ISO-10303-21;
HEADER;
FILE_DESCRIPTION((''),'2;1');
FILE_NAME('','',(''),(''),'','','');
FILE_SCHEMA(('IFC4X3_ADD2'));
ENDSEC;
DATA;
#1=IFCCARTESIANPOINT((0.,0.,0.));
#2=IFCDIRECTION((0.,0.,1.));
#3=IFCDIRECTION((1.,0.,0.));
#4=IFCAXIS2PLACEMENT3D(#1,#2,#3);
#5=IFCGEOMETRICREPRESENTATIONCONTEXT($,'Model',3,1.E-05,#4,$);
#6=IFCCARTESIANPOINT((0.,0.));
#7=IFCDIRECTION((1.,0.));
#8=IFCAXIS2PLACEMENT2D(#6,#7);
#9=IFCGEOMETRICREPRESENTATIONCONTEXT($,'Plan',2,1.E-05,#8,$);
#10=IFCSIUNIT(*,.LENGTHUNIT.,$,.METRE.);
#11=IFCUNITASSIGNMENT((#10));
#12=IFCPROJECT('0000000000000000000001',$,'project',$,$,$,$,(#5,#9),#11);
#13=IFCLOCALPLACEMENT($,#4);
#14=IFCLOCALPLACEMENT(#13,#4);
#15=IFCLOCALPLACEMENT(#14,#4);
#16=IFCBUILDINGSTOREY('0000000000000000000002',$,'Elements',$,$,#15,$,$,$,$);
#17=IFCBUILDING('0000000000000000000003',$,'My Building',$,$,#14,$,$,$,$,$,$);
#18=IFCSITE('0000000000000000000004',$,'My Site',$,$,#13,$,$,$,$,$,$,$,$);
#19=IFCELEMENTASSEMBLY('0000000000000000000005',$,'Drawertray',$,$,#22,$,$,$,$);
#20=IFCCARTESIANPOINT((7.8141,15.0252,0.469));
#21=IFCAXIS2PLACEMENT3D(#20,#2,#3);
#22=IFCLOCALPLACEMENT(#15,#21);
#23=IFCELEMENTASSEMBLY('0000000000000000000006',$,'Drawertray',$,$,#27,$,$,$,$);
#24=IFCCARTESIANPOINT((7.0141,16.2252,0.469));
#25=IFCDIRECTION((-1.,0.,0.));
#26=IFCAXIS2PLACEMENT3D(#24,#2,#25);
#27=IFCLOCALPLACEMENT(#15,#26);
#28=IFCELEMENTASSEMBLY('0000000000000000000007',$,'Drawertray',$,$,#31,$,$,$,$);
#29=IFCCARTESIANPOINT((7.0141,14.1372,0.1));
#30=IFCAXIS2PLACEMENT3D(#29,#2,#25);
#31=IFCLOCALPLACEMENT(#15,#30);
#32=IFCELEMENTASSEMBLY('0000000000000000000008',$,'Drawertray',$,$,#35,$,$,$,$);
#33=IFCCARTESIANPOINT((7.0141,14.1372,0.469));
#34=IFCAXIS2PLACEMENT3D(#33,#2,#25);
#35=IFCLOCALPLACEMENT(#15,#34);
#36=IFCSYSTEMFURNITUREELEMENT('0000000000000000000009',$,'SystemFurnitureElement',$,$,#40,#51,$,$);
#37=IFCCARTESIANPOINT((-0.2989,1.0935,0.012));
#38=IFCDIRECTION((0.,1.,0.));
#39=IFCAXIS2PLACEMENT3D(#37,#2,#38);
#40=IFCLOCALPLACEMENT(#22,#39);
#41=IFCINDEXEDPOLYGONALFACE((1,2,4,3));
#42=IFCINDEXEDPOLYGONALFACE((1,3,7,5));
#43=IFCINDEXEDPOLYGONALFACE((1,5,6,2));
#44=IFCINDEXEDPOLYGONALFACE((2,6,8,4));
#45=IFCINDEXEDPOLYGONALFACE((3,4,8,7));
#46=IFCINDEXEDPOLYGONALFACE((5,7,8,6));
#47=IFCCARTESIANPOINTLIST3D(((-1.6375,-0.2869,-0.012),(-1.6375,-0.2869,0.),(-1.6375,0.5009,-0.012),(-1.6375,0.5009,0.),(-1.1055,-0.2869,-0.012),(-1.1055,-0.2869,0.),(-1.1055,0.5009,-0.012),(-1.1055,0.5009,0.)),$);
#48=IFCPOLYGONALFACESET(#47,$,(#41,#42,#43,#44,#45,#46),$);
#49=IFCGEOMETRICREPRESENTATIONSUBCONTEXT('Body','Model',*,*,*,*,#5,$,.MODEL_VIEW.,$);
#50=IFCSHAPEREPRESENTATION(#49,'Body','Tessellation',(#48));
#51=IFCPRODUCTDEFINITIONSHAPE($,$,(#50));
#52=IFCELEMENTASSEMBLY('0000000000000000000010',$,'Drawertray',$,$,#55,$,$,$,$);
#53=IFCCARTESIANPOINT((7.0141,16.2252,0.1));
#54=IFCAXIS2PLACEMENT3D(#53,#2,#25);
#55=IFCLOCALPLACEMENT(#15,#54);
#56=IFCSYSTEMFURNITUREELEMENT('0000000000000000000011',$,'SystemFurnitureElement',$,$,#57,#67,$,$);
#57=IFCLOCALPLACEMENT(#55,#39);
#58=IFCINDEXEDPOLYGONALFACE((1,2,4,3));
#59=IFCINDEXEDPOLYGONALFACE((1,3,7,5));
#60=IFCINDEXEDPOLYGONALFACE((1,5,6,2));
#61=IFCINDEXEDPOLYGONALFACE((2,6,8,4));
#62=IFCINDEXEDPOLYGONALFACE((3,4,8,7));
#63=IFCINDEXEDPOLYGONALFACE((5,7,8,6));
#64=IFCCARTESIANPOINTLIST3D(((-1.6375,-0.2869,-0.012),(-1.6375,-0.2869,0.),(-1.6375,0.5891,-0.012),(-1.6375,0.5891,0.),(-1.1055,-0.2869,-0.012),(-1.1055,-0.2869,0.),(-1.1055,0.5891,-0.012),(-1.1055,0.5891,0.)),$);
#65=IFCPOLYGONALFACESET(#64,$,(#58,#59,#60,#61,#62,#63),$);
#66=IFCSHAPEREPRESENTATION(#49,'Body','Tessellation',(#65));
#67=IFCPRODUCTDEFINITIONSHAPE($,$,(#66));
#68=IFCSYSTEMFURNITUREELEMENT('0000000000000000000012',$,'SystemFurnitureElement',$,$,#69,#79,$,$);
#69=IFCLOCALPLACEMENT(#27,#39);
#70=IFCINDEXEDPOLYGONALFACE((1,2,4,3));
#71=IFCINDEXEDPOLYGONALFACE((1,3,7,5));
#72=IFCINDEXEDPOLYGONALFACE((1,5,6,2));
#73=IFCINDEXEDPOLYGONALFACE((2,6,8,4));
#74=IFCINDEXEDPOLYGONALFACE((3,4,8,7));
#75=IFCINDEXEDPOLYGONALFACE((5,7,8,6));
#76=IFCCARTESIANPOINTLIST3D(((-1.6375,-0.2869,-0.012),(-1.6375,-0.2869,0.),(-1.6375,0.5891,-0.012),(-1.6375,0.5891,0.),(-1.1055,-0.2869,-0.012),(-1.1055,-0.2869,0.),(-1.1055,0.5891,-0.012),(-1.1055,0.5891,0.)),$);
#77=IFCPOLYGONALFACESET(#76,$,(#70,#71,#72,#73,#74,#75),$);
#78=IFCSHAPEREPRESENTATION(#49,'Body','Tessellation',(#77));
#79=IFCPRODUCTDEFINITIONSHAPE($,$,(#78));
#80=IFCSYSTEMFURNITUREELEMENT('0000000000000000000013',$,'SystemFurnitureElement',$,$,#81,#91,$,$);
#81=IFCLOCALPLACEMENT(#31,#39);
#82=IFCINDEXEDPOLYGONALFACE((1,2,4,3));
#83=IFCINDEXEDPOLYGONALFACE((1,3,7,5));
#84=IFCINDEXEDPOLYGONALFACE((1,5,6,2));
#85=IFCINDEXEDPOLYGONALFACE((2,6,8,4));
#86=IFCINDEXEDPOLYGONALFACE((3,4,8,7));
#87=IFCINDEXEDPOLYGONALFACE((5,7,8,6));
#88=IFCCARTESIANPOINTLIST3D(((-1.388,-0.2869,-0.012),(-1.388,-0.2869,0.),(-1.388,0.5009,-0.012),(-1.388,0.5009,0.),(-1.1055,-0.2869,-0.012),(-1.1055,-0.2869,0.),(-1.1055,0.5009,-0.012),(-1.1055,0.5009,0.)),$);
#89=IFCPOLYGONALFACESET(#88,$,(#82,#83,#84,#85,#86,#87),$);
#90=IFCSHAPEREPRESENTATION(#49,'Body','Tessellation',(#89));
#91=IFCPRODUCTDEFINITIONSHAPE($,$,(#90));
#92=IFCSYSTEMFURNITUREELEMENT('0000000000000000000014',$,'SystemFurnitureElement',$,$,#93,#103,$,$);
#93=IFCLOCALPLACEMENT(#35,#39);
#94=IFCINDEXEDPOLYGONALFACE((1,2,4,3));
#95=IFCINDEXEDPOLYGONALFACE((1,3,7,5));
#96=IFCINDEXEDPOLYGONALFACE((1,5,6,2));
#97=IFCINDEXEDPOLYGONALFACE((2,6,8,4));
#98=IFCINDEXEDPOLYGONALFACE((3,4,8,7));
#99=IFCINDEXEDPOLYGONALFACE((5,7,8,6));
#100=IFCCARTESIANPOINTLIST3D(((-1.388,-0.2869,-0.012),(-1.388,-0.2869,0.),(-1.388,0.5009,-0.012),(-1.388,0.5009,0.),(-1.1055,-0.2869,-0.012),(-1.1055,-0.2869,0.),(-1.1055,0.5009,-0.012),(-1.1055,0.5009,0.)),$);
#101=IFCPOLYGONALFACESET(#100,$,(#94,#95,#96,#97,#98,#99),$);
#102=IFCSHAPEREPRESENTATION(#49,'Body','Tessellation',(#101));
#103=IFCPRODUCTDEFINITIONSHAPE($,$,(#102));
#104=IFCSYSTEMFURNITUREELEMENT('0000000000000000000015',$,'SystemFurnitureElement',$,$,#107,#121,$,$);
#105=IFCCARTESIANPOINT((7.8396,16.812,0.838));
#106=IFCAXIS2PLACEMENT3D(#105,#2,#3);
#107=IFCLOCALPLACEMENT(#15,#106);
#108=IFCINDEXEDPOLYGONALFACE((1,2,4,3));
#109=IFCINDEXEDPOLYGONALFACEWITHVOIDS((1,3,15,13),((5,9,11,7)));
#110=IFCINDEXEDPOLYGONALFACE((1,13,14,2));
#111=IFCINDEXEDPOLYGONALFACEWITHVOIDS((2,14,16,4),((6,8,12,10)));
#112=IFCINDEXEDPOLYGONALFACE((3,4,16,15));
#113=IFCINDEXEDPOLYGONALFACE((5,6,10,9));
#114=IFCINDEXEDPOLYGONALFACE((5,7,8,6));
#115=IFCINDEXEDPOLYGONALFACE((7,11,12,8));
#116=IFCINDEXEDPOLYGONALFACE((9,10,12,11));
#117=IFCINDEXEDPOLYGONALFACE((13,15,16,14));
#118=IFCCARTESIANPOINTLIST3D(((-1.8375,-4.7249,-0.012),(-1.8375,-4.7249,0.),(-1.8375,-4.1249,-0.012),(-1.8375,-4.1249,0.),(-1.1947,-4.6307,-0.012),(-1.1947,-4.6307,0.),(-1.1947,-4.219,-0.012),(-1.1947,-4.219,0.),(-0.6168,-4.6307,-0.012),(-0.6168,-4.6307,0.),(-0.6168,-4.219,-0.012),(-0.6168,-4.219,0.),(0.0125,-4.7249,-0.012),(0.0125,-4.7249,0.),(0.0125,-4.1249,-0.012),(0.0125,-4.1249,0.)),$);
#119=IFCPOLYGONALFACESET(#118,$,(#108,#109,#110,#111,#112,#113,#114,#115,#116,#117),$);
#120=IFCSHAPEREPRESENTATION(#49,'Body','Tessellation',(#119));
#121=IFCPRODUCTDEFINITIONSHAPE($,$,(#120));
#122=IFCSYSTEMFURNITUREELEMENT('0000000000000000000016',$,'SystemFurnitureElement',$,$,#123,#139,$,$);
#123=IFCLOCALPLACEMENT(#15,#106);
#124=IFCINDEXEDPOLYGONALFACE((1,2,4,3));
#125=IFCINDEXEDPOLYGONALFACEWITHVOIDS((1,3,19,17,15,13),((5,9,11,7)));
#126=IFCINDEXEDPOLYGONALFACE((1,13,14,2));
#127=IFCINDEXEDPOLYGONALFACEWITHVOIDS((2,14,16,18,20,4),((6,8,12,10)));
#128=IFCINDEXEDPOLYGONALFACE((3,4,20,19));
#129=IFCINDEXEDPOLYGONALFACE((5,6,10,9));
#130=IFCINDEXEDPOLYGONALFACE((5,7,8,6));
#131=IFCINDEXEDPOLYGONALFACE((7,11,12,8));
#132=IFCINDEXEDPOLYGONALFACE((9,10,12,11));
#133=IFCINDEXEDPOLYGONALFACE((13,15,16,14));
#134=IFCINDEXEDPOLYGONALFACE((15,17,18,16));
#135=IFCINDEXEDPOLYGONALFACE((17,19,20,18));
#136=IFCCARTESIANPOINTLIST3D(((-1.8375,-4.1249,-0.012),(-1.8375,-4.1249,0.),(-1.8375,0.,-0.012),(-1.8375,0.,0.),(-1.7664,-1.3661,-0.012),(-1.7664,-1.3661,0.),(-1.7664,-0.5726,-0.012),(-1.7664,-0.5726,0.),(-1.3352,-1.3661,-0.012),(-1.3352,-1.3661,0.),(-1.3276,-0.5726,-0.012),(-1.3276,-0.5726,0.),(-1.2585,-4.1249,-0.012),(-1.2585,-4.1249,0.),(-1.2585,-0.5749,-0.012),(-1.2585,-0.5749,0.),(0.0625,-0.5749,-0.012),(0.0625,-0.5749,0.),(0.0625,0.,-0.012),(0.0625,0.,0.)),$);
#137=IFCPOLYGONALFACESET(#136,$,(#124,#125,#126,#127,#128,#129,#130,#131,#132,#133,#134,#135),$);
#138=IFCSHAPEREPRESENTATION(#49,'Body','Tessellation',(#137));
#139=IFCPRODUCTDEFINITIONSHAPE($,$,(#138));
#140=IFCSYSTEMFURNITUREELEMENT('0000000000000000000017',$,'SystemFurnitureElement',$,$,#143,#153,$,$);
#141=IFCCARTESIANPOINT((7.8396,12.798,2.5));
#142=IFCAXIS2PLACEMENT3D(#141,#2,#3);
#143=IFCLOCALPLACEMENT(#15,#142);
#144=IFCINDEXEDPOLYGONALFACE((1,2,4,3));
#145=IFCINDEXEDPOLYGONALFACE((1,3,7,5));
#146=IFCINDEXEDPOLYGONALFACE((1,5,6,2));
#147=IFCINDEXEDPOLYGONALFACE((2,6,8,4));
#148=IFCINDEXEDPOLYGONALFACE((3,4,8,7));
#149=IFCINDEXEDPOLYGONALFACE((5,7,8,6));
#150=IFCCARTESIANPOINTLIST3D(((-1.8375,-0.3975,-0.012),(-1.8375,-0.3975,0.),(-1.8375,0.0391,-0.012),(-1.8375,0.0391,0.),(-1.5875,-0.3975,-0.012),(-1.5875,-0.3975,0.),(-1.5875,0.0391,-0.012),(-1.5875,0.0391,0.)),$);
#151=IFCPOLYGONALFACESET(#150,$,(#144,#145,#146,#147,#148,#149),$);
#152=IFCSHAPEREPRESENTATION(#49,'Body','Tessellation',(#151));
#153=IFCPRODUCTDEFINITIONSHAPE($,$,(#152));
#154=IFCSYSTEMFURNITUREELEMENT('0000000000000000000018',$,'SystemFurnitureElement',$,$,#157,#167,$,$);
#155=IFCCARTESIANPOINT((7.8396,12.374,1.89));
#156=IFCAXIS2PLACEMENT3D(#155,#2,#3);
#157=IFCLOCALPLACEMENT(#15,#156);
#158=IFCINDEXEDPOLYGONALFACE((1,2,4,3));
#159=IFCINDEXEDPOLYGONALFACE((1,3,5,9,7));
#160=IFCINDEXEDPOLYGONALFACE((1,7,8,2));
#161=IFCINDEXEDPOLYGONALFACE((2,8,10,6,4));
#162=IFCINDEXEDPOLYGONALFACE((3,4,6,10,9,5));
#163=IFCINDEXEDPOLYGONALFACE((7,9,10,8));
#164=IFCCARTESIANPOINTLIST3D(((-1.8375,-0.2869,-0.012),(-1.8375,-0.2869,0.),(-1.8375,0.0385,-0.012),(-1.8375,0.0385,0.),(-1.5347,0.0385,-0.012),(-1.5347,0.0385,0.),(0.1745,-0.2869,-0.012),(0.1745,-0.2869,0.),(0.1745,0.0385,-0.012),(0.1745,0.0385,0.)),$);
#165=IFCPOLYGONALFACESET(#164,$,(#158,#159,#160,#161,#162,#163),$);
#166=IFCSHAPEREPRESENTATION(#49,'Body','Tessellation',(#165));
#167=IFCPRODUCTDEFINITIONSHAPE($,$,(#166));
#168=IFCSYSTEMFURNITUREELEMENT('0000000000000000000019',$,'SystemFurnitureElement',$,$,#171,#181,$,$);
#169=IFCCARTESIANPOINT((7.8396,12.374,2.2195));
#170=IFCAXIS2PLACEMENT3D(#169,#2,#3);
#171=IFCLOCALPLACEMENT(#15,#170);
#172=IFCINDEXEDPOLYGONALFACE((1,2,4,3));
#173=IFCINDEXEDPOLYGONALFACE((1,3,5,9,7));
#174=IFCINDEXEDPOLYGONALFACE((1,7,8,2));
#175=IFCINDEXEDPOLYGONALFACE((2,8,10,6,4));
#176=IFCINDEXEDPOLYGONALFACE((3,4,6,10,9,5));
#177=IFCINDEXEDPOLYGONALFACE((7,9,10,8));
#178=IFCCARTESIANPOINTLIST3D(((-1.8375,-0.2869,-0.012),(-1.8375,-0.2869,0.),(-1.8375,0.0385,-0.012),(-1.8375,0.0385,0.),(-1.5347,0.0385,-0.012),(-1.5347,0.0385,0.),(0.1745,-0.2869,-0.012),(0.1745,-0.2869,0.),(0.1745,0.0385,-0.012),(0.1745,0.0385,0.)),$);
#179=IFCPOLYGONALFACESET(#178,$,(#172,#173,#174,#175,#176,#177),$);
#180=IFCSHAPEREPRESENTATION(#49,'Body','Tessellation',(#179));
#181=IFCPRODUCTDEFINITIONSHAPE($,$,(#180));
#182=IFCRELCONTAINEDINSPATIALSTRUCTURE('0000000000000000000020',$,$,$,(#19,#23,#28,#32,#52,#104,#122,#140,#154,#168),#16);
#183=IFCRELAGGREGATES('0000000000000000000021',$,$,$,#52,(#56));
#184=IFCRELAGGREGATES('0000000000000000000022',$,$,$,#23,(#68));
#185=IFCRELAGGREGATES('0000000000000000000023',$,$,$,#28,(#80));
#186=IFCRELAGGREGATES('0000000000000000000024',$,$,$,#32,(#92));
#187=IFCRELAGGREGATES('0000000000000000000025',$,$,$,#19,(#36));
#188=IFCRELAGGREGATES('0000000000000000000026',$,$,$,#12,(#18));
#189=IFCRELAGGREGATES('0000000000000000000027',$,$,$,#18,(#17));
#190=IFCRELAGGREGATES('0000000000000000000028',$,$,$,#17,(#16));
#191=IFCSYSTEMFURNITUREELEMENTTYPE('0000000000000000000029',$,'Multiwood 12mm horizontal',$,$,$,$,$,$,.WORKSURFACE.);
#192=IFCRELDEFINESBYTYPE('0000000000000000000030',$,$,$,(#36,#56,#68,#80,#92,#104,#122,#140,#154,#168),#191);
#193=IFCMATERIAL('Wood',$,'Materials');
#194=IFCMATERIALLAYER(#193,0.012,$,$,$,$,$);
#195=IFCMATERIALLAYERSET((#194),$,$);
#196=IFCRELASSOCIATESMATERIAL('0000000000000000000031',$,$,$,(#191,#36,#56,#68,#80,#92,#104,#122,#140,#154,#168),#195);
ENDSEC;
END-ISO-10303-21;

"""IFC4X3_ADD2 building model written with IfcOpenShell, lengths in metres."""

from ifc_helpers import new_model, si_unit, frame, origin_with_axes, origin_2d_with_axis, place, context, subcontext, project, spatial, indexed_curve, outline, extrude, material, layer, layer_set, layer_usage, type_object, element, aggregate, save


model = new_model("IFC4X3_ADD2")

# Units and contexts
model_context = context("Model", 3, precision=1e-05, world=origin_with_axes())
plan_context = context("Plan", 2, precision=1e-05, world=origin_2d_with_axis())
body_context = subcontext(model_context, "Body", "Model", "MODEL_VIEW")
ifc_project = project(units=[si_unit("LENGTHUNIT", "METRE")], contexts=[model_context, plan_context])

# Site, building, storey
site_placement = place(None, origin_with_axes())
site = spatial("IfcSite", under=ifc_project, at=site_placement, Name="My Site")
building_placement = place(site_placement, origin_with_axes())
building = spatial("IfcBuilding", under=site, at=building_placement, Name="My Building")
storey_placement = place(building_placement, origin_with_axes())
storey = spatial("IfcBuildingStorey", under=building, at=storey_placement, Name="Elements")

# Shared definitions
ifc_material_1 = material(Name="Wood", Category="Materials")

# Element assemblies
assembly_1_placement = place(storey_placement, frame((7.8141, 15.0252, 0.469), z_axis=(0.0, 0.0, 1.0), x_axis=(1.0, 0.0, 0.0)))
assembly_1 = element("IfcElementAssembly", 1, at=assembly_1_placement, inside=storey, Name="Drawertray")
assembly_2_placement = place(storey_placement, frame((7.0141, 16.2252, 0.469), z_axis=(0.0, 0.0, 1.0), x_axis=(-1.0, 0.0, 0.0)))
assembly_2 = element("IfcElementAssembly", 2, at=assembly_2_placement, inside=storey, Name="Drawertray")

# Element assemblies
assembly_3_placement = place(storey_placement, frame((7.0141, 14.1372, 0.1), z_axis=(0.0, 0.0, 1.0), x_axis=(-1.0, 0.0, 0.0)))
assembly_3 = element("IfcElementAssembly", 3, at=assembly_3_placement, inside=storey, Name="Drawertray")
assembly_4_placement = place(storey_placement, frame((7.0141, 14.1372, 0.469), z_axis=(0.0, 0.0, 1.0), x_axis=(-1.0, 0.0, 0.0)))
assembly_4 = element("IfcElementAssembly", 4, at=assembly_4_placement, inside=storey, Name="Drawertray")

# Shared definitions
ifc_layer_1 = layer(ifc_material_1, 0.012)
ifc_layer_set_1 = layer_set([ifc_layer_1])
system_furniture_element_type_1 = type_object("IfcSystemFurnitureElementType", Name="Multiwood 12mm horizontal", PredefinedType="WORKSURFACE", material=ifc_layer_set_1)

# System furniture element
ifc_layer_usage_1 = layer_usage(ifc_layer_set_1, "AXIS3", "POSITIVE", -0.012)
system_furniture_element_1_placement = place(assembly_1_placement, frame((-0.2989, 1.0935, 0.012), z_axis=(0.0, 0.0, 1.0), x_axis=(0.0, 1.0, 0.0)))
system_furniture_element_1 = element("IfcSystemFurnitureElement", 5, at=system_furniture_element_1_placement, type_object=system_furniture_element_type_1, material=ifc_layer_usage_1, Name="SystemFurnitureElement", context=body_context, shape_type="SweptSolid", body=[
    extrude(outline(indexed_curve([(-1.6375, 0.5009), (-1.1055, 0.5009), (-1.1055, -0.2869), (-1.6375, -0.2869), (-1.6375, 0.5009)])), frame((0.0, 0.0, -0.012), z_axis=(0.0, 0.0, 1.0), x_axis=(1.0, 0.0, 0.0)), (0.0, 0.0, 1.0), 0.012),
])

# Element assembly, system furniture element
assembly_5_placement = place(storey_placement, frame((7.0141, 16.2252, 0.1), z_axis=(0.0, 0.0, 1.0), x_axis=(-1.0, 0.0, 0.0)))
assembly_5 = element("IfcElementAssembly", 6, at=assembly_5_placement, inside=storey, Name="Drawertray")
ifc_layer_usage_2 = layer_usage(ifc_layer_set_1, "AXIS3", "POSITIVE", -0.012)
system_furniture_element_2_placement = place(assembly_5_placement, frame((-0.2989, 1.0935, 0.012), z_axis=(0.0, 0.0, 1.0), x_axis=(0.0, 1.0, 0.0)))
system_furniture_element_2 = element("IfcSystemFurnitureElement", 7, at=system_furniture_element_2_placement, type_object=system_furniture_element_type_1, material=ifc_layer_usage_2, Name="SystemFurnitureElement", context=body_context, shape_type="SweptSolid", body=[
    extrude(outline(indexed_curve([(-1.6375, -0.2869), (-1.1055, -0.2869), (-1.1055, 0.5891), (-1.6375, 0.5891), (-1.6375, -0.2869)])), frame((0.0, 0.0, -0.012), z_axis=(0.0, 0.0, 1.0), x_axis=(1.0, 0.0, 0.0)), (0.0, 0.0, 1.0), 0.012),
])
aggregate(assembly_5, [system_furniture_element_2])

# System furniture elements
ifc_layer_usage_3 = layer_usage(ifc_layer_set_1, "AXIS3", "POSITIVE", -0.012)
system_furniture_element_3_placement = place(assembly_2_placement, frame((-0.2989, 1.0935, 0.012), z_axis=(0.0, 0.0, 1.0), x_axis=(0.0, 1.0, 0.0)))
system_furniture_element_3 = element("IfcSystemFurnitureElement", 8, at=system_furniture_element_3_placement, type_object=system_furniture_element_type_1, material=ifc_layer_usage_3, Name="SystemFurnitureElement", context=body_context, shape_type="SweptSolid", body=[
    extrude(outline(indexed_curve([(-1.6375, 0.5891), (-1.1055, 0.5891), (-1.1055, -0.2869), (-1.6375, -0.2869), (-1.6375, 0.5891)])), frame((0.0, 0.0, -0.012), z_axis=(0.0, 0.0, 1.0), x_axis=(1.0, 0.0, 0.0)), (0.0, 0.0, 1.0), 0.012),
])
aggregate(assembly_2, [system_furniture_element_3])
ifc_layer_usage_4 = layer_usage(ifc_layer_set_1, "AXIS3", "POSITIVE", -0.012)
system_furniture_element_4_placement = place(assembly_3_placement, frame((-0.2989, 1.0935, 0.012), z_axis=(0.0, 0.0, 1.0), x_axis=(0.0, 1.0, 0.0)))
system_furniture_element_4 = element("IfcSystemFurnitureElement", 9, at=system_furniture_element_4_placement, type_object=system_furniture_element_type_1, material=ifc_layer_usage_4, Name="SystemFurnitureElement", context=body_context, shape_type="SweptSolid", body=[
    extrude(outline(indexed_curve([(-1.388, -0.2869), (-1.1055, -0.2869), (-1.1055, 0.5009), (-1.388, 0.5009), (-1.388, -0.2869)])), frame((0.0, 0.0, -0.012), z_axis=(0.0, 0.0, 1.0), x_axis=(1.0, 0.0, 0.0)), (0.0, 0.0, 1.0), 0.012),
])
aggregate(assembly_3, [system_furniture_element_4])
ifc_layer_usage_5 = layer_usage(ifc_layer_set_1, "AXIS3", "POSITIVE", -0.012)
system_furniture_element_5_placement = place(assembly_4_placement, frame((-0.2989, 1.0935, 0.012), z_axis=(0.0, 0.0, 1.0), x_axis=(0.0, 1.0, 0.0)))
system_furniture_element_5 = element("IfcSystemFurnitureElement", 10, at=system_furniture_element_5_placement, type_object=system_furniture_element_type_1, material=ifc_layer_usage_5, Name="SystemFurnitureElement", context=body_context, shape_type="SweptSolid", body=[
    extrude(outline(indexed_curve([(-1.388, -0.2869), (-1.1055, -0.2869), (-1.1055, 0.5009), (-1.388, 0.5009), (-1.388, -0.2869)])), frame((0.0, 0.0, -0.012), z_axis=(0.0, 0.0, 1.0), x_axis=(1.0, 0.0, 0.0)), (0.0, 0.0, 1.0), 0.012),
])
aggregate(assembly_4, [system_furniture_element_5])

# System furniture elements
ifc_layer_usage_6 = layer_usage(ifc_layer_set_1, "AXIS3", "POSITIVE", -0.012)
system_furniture_element_6_placement = place(storey_placement, frame((7.8396, 16.812, 0.838), z_axis=(0.0, 0.0, 1.0), x_axis=(1.0, 0.0, 0.0)))
element("IfcSystemFurnitureElement", 11, at=system_furniture_element_6_placement, inside=storey, type_object=system_furniture_element_type_1, material=ifc_layer_usage_6, Name="SystemFurnitureElement", context=body_context, shape_type="SweptSolid", body=[
    extrude(outline(indexed_curve([(-1.8375, -4.1249), (0.0125, -4.1249), (0.0125, -4.7249), (-1.8375, -4.7249), (-1.8375, -4.1249)]), holes=[indexed_curve([(-1.1947, -4.219), (-0.6168, -4.219), (-0.6168, -4.6307), (-1.1947, -4.6307), (-1.1947, -4.219)])]), frame((0.0, 0.0, -0.012), z_axis=(0.0, 0.0, 1.0), x_axis=(1.0, 0.0, 0.0)), (0.0, 0.0, 1.0), 0.012),
])
ifc_layer_usage_7 = layer_usage(ifc_layer_set_1, "AXIS3", "POSITIVE", -0.012)
system_furniture_element_7_placement = place(storey_placement, frame((7.8396, 16.812, 0.838), z_axis=(0.0, 0.0, 1.0), x_axis=(1.0, 0.0, 0.0)))
element("IfcSystemFurnitureElement", 12, at=system_furniture_element_7_placement, inside=storey, type_object=system_furniture_element_type_1, material=ifc_layer_usage_7, Name="SystemFurnitureElement", context=body_context, shape_type="SweptSolid", body=[
    extrude(outline(indexed_curve([(0.0625, 0.0), (-1.8375, 0.0), (-1.8375, -4.1249), (-1.2585, -4.1249), (-1.2585, -0.5749), (0.0625, -0.5749), (0.0625, 0.0)]), holes=[indexed_curve([(-1.3276, -0.5726), (-1.7664, -0.5726), (-1.7664, -1.3661), (-1.3352, -1.3661), (-1.3276, -0.5726)])]), frame((0.0, 0.0, -0.012), z_axis=(0.0, 0.0, 1.0), x_axis=(1.0, 0.0, 0.0)), (0.0, 0.0, 1.0), 0.012),
])
ifc_layer_usage_8 = layer_usage(ifc_layer_set_1, "AXIS3", "POSITIVE", -0.012)
system_furniture_element_8_placement = place(storey_placement, frame((7.8396, 12.798, 2.5), z_axis=(0.0, 0.0, 1.0), x_axis=(1.0, 0.0, 0.0)))
element("IfcSystemFurnitureElement", 13, at=system_furniture_element_8_placement, inside=storey, type_object=system_furniture_element_type_1, material=ifc_layer_usage_8, Name="SystemFurnitureElement", context=body_context, shape_type="SweptSolid", body=[
    extrude(outline(indexed_curve([(-1.8375, 0.0391), (-1.5875, 0.0391), (-1.5875, -0.3975), (-1.8375, -0.3975), (-1.8375, 0.0391)])), frame((0.0, 0.0, -0.012), z_axis=(0.0, 0.0, 1.0), x_axis=(1.0, 0.0, 0.0)), (0.0, 0.0, 1.0), 0.012),
])
ifc_layer_usage_9 = layer_usage(ifc_layer_set_1, "AXIS3", "POSITIVE", -0.012)
system_furniture_element_9_placement = place(storey_placement, frame((7.8396, 12.374, 1.89), z_axis=(0.0, 0.0, 1.0), x_axis=(1.0, 0.0, 0.0)))
element("IfcSystemFurnitureElement", 14, at=system_furniture_element_9_placement, inside=storey, type_object=system_furniture_element_type_1, material=ifc_layer_usage_9, Name="SystemFurnitureElement", context=body_context, shape_type="SweptSolid", body=[
    extrude(outline(indexed_curve([(0.1745, -0.2869), (-1.8375, -0.2869), (-1.8375, 0.0385), (-1.5347, 0.0385), (0.1745, 0.0385), (0.1745, -0.2869)])), frame((0.0, 0.0, -0.012), z_axis=(0.0, 0.0, 1.0), x_axis=(1.0, 0.0, 0.0)), (0.0, 0.0, 1.0), 0.012),
])
ifc_layer_usage_10 = layer_usage(ifc_layer_set_1, "AXIS3", "POSITIVE", -0.012)
system_furniture_element_10_placement = place(storey_placement, frame((7.8396, 12.374, 2.2195), z_axis=(0.0, 0.0, 1.0), x_axis=(1.0, 0.0, 0.0)))
element("IfcSystemFurnitureElement", 15, at=system_furniture_element_10_placement, inside=storey, type_object=system_furniture_element_type_1, material=ifc_layer_usage_10, Name="SystemFurnitureElement", context=body_context, shape_type="SweptSolid", body=[
    extrude(outline(indexed_curve([(0.1745, -0.2869), (-1.8375, -0.2869), (-1.8375, 0.0385), (-1.5347, 0.0385), (0.1745, 0.0385), (0.1745, -0.2869)])), frame((0.0, 0.0, -0.012), z_axis=(0.0, 0.0, 1.0), x_axis=(1.0, 0.0, 0.0)), (0.0, 0.0, 1.0), 0.012),
])

aggregate(assembly_1, [system_furniture_element_1])

save(model, "model.ifc")
